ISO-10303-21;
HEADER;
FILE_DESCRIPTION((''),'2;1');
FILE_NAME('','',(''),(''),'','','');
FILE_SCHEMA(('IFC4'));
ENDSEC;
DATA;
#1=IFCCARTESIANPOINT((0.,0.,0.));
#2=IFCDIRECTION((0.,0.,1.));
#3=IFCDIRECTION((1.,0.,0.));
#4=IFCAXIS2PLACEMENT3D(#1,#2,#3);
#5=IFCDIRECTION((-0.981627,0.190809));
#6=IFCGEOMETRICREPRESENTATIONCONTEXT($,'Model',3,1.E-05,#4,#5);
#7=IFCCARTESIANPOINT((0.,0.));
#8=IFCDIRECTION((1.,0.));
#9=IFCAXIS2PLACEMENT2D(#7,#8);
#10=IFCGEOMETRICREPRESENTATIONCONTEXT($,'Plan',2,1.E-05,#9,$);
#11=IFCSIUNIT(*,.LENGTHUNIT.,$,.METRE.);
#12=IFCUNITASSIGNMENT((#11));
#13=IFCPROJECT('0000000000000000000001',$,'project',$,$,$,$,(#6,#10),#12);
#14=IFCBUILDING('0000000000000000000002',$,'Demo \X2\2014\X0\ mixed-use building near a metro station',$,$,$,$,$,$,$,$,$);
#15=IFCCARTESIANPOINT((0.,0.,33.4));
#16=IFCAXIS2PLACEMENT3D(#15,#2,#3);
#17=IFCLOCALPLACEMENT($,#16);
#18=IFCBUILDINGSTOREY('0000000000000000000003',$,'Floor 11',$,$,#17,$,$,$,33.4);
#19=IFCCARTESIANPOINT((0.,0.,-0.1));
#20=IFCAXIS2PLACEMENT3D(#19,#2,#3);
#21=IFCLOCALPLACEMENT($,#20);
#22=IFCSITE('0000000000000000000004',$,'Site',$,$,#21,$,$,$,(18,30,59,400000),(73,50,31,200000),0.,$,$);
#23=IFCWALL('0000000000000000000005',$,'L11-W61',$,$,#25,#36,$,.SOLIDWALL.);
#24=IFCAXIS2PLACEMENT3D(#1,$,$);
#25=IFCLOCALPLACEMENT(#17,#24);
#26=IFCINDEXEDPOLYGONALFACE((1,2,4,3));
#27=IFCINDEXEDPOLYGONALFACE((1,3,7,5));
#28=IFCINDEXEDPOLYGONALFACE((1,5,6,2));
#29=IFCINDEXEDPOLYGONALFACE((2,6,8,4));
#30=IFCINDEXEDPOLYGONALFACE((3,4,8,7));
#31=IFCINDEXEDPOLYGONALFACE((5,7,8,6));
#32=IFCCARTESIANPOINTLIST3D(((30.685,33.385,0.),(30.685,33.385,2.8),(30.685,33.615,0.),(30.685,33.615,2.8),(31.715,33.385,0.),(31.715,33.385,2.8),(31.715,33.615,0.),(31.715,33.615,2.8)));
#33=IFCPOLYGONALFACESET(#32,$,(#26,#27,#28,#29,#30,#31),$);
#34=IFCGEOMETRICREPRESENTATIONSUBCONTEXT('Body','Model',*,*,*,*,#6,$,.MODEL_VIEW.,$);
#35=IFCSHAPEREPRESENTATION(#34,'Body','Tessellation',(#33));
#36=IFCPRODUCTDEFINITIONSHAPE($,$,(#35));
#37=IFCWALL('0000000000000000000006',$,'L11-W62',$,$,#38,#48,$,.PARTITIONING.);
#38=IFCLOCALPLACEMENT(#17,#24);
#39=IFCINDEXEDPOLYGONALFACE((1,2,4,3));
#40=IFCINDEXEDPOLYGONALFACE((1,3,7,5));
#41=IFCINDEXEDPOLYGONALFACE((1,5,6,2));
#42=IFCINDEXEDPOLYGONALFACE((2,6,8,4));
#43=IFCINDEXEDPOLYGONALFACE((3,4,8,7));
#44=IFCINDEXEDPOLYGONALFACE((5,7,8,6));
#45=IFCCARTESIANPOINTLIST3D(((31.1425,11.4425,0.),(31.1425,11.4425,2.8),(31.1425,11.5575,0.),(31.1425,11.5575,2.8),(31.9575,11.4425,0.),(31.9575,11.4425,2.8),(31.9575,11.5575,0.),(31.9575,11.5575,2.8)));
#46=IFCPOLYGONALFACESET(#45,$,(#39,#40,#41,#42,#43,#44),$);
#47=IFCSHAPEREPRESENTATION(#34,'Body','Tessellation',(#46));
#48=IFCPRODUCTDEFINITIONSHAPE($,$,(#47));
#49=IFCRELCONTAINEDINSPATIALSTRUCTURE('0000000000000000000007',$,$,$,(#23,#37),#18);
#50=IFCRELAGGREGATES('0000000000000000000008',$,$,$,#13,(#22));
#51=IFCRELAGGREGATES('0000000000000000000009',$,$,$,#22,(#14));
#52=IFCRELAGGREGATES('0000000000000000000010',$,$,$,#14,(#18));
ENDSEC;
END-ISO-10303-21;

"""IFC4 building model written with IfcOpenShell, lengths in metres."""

from ifc_helpers import new_model, si_unit, direction, frame, origin_with_axes, origin_2d_with_axis, place, context, subcontext, project, spatial, line, indexed_curve, outline, extrude, element, save


model = new_model("IFC4")

# Units and contexts
model_context = context("Model", 3, precision=1e-05, world=origin_with_axes(), true_north=direction((-0.981627, 0.190809)))
plan_context = context("Plan", 2, precision=1e-05, world=origin_2d_with_axis())
body_context = subcontext(model_context, "Body", "Model", "MODEL_VIEW")
ifc_project = project(units=[si_unit("LENGTHUNIT", "METRE")], contexts=[model_context, plan_context])

# Site, building, storey
site_placement = place(None, frame((0.0, 0.0, -0.1), z_axis=(0.0, 0.0, 1.0), x_axis=(1.0, 0.0, 0.0)))
site = spatial("IfcSite", under=ifc_project, at=site_placement, Name="Site", RefLatitude=(18, 30, 59, 400000), RefLongitude=(73, 50, 31, 200000), RefElevation=0.0)
building = spatial("IfcBuilding", under=site, Name="Demo — mixed-use building near a metro station")
storey_placement = place(None, frame((0.0, 0.0, 33.4), z_axis=(0.0, 0.0, 1.0), x_axis=(1.0, 0.0, 0.0)))
storey = spatial("IfcBuildingStorey", under=building, at=storey_placement, Name="Floor 11", Elevation=33.4)

# Walls
wall_1_placement = place(storey_placement, frame((0.0, 0.0, -33.4), z_axis=(0.0, 0.0, 1.0), x_axis=(1.0, 0.0, 0.0)))
element("IfcWall", 1, at=wall_1_placement, inside=storey, Name="L11-W61", PredefinedType="SOLIDWALL", context=body_context, shape_type="SweptSolid", body=[
    extrude(outline(indexed_curve([(31.715, 33.385), (30.685, 33.385), (30.685, 33.615), (31.715, 33.615)], segments=[line(1, 2, 3, 4, 1)])), frame((0.0, 0.0, 33.4), z_axis=(0.0, 0.0, 1.0), x_axis=(1.0, 0.0, 0.0)), (0.0, 0.0, 1.0), 2.8),
])
wall_2_placement = place(storey_placement, frame((0.0, 0.0, -33.4), z_axis=(0.0, 0.0, 1.0), x_axis=(1.0, 0.0, 0.0)))
element("IfcWall", 2, at=wall_2_placement, inside=storey, Name="L11-W62", PredefinedType="PARTITIONING", context=body_context, shape_type="SweptSolid", body=[
    extrude(outline(indexed_curve([(31.1425, 11.5575), (31.9575, 11.5575), (31.9575, 11.4425), (31.1425, 11.4425)], segments=[line(1, 2, 3, 4, 1)])), frame((0.0, 0.0, 33.4), z_axis=(0.0, 0.0, 1.0), x_axis=(1.0, 0.0, 0.0)), (0.0, 0.0, 1.0), 2.8),
])

save(model, "model.ifc")
